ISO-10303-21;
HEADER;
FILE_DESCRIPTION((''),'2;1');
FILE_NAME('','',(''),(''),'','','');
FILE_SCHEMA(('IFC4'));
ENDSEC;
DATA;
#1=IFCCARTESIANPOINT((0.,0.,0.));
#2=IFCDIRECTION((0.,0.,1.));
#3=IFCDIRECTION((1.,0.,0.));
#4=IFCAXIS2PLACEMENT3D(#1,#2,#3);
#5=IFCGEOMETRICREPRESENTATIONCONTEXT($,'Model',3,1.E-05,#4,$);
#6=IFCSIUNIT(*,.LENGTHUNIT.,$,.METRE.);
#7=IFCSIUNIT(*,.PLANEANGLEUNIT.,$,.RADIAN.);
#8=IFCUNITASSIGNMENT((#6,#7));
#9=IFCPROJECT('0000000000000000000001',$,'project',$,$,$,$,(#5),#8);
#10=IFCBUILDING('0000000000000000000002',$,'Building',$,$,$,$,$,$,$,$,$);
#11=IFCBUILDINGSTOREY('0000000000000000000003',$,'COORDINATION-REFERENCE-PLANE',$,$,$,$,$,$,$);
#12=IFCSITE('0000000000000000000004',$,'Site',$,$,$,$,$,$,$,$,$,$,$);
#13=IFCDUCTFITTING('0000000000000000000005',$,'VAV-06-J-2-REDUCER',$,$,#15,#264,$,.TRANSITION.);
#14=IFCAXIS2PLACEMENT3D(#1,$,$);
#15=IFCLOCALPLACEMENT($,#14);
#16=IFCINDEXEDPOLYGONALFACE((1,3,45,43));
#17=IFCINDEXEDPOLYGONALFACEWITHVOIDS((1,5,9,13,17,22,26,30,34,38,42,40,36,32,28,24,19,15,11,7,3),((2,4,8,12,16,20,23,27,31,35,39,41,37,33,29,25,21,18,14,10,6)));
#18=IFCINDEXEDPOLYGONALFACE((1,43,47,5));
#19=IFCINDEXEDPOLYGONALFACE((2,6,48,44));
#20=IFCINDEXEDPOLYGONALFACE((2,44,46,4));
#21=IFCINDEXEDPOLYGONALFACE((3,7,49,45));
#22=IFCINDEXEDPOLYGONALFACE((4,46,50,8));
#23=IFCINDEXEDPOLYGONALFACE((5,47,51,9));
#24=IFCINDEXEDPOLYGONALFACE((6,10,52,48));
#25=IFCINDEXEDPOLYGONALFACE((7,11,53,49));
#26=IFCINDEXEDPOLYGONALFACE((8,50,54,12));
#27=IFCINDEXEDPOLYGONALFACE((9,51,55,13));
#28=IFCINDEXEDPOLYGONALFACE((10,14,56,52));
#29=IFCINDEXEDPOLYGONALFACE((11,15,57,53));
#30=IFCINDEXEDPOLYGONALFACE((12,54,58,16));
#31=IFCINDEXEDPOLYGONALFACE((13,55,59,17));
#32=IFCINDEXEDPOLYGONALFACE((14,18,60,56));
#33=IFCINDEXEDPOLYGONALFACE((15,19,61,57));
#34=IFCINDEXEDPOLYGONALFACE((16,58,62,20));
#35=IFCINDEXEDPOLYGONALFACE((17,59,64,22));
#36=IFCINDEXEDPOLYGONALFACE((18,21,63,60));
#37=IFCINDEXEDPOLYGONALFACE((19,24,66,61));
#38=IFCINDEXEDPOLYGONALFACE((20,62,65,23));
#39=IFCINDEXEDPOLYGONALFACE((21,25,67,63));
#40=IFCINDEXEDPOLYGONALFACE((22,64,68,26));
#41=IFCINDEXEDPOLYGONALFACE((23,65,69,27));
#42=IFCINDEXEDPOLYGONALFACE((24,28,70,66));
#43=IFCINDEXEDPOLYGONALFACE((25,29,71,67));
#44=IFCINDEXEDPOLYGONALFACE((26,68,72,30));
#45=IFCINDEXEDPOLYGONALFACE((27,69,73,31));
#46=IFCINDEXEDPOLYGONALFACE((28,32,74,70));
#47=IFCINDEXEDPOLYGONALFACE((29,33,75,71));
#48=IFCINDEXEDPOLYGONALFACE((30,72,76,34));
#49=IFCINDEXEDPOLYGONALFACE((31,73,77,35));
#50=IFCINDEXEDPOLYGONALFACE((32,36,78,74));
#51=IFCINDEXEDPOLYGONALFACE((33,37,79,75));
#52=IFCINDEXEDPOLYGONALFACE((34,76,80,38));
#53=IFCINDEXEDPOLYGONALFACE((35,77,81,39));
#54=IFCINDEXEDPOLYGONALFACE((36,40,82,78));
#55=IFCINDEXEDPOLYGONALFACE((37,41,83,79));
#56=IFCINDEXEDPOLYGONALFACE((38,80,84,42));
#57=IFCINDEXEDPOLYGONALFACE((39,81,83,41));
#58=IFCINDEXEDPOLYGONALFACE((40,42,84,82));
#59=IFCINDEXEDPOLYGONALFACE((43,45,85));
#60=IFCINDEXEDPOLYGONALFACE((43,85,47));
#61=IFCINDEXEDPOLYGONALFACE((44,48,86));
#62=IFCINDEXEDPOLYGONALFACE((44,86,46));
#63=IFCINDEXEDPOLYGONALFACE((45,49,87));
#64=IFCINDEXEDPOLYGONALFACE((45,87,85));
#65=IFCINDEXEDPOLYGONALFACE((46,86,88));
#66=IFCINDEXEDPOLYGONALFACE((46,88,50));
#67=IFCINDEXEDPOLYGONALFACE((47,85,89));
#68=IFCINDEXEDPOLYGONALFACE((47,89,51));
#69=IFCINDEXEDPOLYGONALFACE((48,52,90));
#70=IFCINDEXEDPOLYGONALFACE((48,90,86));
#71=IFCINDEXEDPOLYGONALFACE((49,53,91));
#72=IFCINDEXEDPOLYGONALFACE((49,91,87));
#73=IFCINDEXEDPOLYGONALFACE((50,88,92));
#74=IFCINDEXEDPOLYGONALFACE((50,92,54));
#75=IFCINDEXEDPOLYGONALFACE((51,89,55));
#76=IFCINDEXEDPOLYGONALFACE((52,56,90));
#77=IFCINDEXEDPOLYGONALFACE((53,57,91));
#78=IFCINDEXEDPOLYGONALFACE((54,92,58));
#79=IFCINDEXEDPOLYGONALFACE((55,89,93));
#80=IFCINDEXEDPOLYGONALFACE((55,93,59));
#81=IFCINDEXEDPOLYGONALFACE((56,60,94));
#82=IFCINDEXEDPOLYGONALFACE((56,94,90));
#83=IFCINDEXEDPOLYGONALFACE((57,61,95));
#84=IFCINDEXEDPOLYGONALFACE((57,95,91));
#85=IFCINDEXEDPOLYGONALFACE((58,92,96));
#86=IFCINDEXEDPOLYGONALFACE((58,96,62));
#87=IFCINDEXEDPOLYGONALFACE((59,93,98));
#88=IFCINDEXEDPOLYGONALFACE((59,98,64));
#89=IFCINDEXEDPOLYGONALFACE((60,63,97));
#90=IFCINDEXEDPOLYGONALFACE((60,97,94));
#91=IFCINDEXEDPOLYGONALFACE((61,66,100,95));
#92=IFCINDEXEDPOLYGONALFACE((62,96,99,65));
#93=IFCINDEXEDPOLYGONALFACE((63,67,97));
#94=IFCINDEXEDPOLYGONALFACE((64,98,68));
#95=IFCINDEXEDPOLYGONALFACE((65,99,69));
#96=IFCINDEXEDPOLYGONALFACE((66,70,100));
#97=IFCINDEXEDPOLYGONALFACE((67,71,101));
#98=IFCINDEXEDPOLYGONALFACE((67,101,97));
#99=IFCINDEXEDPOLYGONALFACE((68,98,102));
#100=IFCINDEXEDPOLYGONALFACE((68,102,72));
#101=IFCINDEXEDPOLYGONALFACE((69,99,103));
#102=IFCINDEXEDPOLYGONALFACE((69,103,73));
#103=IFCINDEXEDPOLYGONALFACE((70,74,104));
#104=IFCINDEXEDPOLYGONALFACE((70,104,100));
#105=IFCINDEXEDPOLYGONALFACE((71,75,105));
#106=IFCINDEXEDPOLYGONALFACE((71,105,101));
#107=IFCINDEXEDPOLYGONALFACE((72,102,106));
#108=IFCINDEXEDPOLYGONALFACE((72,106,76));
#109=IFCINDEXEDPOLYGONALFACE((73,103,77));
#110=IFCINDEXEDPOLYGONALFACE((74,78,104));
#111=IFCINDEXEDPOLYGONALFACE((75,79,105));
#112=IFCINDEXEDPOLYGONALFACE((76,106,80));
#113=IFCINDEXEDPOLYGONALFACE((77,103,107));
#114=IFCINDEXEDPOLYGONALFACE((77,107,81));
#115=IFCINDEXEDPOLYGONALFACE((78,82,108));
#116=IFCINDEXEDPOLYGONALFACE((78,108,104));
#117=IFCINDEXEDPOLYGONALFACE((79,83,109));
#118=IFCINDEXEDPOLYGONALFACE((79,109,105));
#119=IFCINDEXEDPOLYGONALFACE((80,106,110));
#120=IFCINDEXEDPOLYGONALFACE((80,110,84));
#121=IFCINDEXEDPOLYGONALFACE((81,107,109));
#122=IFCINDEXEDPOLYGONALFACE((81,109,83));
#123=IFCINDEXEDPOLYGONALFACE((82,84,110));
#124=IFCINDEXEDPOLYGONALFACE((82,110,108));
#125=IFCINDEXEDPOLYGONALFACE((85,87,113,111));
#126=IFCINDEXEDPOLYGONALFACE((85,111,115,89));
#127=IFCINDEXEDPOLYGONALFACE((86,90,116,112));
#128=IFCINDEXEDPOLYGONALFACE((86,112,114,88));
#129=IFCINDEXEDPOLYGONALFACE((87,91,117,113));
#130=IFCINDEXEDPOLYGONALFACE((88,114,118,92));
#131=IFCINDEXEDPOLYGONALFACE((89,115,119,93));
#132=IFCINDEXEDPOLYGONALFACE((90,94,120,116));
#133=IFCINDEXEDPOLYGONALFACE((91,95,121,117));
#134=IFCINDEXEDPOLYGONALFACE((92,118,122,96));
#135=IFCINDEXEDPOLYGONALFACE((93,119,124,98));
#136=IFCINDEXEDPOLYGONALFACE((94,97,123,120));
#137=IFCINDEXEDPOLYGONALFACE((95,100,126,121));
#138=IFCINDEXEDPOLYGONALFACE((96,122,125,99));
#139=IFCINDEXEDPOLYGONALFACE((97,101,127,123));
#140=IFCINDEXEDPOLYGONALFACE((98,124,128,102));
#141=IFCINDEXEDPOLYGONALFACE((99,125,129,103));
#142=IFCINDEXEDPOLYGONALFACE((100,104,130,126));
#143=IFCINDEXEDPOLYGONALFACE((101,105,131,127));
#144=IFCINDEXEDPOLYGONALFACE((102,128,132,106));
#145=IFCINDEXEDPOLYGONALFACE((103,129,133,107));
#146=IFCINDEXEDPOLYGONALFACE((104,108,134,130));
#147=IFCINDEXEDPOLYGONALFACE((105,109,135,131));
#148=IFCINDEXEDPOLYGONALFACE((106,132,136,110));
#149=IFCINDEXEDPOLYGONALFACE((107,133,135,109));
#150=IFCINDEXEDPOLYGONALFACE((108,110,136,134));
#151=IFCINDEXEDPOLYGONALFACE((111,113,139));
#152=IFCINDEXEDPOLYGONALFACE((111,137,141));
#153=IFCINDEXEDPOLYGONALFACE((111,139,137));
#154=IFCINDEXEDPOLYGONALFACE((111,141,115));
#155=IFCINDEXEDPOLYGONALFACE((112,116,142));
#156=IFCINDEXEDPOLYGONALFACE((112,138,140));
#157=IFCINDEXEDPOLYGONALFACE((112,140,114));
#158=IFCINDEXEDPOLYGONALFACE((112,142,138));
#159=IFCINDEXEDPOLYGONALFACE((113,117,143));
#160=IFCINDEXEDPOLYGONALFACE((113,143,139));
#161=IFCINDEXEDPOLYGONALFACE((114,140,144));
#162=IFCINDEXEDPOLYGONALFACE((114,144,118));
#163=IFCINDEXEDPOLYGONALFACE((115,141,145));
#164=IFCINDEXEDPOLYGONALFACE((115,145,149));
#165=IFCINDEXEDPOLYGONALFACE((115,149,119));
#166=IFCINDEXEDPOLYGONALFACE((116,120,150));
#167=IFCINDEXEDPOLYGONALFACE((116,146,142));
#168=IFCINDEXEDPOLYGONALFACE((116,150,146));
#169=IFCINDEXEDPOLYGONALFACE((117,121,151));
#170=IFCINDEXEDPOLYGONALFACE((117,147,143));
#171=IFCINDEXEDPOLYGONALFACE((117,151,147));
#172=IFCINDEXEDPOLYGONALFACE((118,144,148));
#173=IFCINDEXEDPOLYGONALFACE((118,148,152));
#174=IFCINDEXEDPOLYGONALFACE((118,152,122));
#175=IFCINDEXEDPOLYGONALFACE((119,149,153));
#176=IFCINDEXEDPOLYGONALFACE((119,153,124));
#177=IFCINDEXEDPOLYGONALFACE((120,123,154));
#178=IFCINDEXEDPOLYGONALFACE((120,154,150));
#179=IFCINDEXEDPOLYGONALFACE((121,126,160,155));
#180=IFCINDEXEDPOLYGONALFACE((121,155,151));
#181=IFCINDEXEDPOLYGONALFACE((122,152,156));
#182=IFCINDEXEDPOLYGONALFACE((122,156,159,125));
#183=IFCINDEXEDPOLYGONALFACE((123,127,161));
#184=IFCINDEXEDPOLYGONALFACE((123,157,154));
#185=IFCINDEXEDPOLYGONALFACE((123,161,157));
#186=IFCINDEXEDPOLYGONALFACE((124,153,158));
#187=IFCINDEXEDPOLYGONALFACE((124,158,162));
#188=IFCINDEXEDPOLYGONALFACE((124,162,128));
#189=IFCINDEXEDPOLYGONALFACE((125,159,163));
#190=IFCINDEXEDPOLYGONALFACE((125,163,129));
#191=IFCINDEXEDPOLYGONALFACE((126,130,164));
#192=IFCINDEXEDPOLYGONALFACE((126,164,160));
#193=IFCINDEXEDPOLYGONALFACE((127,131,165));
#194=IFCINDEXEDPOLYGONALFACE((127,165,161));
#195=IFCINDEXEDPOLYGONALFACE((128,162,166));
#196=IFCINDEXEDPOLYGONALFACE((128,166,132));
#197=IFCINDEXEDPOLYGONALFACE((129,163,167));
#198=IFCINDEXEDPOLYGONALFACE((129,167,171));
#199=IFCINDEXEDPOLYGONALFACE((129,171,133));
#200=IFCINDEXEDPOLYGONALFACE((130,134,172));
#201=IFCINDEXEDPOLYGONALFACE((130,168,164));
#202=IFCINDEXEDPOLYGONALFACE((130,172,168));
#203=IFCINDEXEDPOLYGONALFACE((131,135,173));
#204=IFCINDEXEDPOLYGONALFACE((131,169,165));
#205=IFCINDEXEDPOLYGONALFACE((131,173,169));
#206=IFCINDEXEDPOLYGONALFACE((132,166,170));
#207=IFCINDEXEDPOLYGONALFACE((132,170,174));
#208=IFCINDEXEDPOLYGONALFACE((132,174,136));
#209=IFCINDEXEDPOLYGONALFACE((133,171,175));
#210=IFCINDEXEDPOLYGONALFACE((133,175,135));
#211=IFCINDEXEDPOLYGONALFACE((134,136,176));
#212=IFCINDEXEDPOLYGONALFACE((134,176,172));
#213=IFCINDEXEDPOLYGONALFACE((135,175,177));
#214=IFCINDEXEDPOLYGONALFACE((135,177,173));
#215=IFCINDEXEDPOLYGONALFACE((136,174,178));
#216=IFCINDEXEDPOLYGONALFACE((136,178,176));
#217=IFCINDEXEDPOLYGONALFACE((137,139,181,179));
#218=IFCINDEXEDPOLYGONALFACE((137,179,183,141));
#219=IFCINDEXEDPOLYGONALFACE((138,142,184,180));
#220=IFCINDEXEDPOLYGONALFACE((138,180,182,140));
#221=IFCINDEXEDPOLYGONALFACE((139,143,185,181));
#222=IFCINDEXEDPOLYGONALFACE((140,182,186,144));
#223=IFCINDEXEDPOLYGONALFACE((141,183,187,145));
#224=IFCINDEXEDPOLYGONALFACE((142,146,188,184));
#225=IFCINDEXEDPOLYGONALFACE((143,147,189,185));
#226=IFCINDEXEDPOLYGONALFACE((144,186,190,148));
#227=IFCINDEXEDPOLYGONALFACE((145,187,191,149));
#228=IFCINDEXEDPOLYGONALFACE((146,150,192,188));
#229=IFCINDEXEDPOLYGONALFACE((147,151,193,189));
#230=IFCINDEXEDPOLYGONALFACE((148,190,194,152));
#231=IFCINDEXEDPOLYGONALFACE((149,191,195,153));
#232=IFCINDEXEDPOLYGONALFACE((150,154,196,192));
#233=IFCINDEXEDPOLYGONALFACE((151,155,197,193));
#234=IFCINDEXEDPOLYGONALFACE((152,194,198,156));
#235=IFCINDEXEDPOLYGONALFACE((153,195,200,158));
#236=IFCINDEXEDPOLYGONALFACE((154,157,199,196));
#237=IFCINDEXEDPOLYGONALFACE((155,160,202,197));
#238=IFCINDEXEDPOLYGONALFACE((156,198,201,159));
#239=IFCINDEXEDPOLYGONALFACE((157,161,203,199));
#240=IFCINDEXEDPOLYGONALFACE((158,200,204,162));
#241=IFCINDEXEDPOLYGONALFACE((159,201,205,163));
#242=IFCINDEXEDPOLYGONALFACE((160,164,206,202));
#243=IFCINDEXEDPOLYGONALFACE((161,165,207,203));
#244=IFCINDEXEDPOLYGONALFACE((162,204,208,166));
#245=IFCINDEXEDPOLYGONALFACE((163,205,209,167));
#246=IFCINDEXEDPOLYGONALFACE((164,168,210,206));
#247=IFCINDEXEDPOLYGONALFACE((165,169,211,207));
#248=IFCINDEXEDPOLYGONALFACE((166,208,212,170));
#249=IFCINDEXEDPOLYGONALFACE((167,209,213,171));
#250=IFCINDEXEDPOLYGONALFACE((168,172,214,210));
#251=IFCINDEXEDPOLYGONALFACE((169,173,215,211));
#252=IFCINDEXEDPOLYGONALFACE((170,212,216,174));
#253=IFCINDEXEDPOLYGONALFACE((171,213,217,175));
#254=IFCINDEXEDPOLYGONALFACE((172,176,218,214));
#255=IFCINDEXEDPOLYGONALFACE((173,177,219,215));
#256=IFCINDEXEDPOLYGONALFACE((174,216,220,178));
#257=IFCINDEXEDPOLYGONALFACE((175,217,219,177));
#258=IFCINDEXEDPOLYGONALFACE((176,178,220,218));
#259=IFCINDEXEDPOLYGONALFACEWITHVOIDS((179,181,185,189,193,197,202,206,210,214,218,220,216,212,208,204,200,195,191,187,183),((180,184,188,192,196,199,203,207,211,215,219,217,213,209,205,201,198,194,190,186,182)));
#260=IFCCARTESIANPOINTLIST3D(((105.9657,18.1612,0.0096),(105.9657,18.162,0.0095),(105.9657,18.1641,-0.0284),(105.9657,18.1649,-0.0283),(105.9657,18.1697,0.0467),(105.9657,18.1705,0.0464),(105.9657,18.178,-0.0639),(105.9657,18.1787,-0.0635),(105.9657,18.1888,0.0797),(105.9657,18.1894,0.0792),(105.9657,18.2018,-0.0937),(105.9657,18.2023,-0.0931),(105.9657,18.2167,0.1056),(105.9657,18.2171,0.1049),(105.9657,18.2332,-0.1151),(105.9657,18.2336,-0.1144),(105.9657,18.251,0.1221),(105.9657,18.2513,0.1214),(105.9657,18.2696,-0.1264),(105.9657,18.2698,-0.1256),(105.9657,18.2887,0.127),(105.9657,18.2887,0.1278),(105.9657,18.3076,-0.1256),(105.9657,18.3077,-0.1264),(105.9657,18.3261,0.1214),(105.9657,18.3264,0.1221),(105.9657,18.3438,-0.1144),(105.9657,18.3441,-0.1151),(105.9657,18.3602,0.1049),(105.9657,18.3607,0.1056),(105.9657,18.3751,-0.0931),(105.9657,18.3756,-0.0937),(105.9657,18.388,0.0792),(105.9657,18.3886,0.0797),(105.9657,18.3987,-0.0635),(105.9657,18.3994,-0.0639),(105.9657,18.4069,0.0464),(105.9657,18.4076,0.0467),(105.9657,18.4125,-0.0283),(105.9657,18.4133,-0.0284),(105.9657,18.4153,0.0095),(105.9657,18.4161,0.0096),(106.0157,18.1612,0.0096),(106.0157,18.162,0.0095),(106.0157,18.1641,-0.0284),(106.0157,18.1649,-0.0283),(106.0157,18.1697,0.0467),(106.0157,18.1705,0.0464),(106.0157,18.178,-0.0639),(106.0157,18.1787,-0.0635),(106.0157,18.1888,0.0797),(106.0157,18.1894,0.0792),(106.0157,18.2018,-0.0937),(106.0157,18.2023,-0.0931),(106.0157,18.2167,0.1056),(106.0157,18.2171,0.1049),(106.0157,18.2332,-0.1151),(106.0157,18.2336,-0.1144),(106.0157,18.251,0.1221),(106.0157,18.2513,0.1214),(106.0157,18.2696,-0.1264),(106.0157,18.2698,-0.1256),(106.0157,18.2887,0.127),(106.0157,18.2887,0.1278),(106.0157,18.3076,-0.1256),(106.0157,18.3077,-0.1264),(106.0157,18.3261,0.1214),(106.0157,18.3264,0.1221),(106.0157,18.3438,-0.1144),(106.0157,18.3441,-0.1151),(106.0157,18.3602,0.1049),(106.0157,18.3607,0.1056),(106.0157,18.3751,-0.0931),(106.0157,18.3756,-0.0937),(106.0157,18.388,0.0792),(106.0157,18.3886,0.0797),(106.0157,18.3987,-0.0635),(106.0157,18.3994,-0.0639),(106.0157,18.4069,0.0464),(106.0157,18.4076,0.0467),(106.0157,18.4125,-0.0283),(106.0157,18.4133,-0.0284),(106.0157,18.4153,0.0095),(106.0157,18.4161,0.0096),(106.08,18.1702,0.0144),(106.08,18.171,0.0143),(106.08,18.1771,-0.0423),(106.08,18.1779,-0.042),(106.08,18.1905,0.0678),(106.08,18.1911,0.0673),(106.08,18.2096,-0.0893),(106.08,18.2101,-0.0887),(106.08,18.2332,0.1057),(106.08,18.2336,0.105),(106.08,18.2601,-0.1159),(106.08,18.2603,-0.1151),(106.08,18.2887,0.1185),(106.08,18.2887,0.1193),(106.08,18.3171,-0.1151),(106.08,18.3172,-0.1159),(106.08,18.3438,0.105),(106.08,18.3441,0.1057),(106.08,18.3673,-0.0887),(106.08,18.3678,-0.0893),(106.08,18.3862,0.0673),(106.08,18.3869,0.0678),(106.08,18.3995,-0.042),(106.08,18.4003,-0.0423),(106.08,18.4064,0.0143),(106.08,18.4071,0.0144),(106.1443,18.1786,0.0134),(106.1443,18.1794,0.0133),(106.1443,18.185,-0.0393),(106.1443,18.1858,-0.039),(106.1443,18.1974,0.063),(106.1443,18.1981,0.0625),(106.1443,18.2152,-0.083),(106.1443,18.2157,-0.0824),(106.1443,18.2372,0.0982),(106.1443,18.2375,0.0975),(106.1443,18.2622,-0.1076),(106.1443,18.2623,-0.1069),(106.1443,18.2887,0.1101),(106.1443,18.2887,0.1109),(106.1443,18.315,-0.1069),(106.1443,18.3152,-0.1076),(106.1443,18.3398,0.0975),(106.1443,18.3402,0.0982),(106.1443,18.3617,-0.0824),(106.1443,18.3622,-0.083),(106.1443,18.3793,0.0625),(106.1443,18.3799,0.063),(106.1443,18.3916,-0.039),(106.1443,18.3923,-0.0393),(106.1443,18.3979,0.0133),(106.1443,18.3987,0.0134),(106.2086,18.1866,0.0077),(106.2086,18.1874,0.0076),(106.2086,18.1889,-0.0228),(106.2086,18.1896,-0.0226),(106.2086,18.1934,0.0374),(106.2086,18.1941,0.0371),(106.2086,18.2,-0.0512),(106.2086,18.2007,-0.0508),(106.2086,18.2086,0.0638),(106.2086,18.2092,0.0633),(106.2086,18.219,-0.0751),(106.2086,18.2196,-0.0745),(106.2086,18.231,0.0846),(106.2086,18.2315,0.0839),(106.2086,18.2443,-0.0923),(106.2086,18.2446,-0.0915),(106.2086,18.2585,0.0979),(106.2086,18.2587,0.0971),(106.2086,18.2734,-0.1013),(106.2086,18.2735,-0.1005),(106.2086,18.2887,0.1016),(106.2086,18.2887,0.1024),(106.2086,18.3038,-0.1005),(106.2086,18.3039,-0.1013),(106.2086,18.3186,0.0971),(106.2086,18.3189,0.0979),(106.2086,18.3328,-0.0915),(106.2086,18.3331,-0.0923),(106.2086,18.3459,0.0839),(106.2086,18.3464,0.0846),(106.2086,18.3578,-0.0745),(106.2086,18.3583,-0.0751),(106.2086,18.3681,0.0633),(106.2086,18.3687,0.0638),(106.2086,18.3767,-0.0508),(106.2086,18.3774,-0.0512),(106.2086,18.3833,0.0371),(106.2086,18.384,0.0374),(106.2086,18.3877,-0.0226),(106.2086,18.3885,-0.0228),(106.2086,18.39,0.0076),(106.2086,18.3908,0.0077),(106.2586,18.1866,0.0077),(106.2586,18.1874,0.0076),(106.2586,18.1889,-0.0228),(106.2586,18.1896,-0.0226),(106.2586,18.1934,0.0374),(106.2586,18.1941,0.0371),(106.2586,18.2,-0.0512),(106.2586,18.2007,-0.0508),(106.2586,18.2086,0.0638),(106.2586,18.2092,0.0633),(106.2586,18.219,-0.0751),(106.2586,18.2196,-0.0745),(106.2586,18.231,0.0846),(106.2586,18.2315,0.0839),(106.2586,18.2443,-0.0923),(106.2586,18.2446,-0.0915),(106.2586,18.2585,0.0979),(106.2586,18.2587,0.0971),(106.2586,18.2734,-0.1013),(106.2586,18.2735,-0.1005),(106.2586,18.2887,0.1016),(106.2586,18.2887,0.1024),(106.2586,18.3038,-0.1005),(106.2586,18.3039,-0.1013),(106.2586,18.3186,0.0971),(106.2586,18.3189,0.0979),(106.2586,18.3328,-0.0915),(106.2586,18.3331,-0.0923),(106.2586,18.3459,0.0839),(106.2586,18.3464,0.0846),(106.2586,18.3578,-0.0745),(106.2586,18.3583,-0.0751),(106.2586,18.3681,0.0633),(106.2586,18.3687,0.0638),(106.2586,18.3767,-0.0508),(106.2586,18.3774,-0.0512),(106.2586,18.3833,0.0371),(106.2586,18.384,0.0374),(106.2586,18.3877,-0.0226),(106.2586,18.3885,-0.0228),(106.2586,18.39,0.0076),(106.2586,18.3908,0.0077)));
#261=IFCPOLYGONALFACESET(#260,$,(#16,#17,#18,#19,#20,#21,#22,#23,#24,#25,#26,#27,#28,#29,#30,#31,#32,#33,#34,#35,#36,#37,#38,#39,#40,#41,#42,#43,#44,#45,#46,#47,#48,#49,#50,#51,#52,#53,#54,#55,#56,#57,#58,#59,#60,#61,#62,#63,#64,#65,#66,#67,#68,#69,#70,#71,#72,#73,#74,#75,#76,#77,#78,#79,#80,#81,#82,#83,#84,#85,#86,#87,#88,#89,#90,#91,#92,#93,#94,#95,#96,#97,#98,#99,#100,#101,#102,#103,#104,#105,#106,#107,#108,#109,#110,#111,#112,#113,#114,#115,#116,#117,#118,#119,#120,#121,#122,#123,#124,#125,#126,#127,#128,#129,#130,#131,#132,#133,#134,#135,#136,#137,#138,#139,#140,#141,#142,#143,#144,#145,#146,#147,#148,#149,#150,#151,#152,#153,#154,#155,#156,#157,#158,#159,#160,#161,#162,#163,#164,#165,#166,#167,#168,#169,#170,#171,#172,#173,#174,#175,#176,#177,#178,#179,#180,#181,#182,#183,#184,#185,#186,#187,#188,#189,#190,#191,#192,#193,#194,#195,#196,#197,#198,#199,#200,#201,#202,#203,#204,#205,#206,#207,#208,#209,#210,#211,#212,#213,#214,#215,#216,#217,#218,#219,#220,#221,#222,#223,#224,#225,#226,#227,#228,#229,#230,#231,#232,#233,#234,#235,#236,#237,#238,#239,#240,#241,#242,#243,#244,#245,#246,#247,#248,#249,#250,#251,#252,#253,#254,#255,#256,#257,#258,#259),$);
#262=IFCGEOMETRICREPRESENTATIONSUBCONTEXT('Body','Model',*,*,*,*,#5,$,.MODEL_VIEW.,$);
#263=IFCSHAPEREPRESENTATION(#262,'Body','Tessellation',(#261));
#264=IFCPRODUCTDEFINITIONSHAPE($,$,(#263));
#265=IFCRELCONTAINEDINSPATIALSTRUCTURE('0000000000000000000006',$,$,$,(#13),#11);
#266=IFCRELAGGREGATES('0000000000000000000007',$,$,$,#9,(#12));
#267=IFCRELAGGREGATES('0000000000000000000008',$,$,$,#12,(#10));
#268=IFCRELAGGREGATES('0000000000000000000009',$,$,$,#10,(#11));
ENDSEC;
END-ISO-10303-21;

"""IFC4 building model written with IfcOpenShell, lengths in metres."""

from ifc_helpers import new_model, entity, si_unit, frame, origin_with_axes, place, context, subcontext, project, spatial, element, save


model = new_model("IFC4")

# Units and contexts
model_context = context("Model", 3, precision=1e-05, world=origin_with_axes())
body_context_1 = subcontext(model_context, "Body", "Model", "MODEL_VIEW")
ifc_project = project(units=[si_unit("LENGTHUNIT", "METRE"), si_unit("PLANEANGLEUNIT", "RADIAN")], contexts=[model_context])

# Site, building, storey
site = spatial("IfcSite", under=ifc_project, Name="Site")
building = spatial("IfcBuilding", under=site, Name="Building")
storey = spatial("IfcBuildingStorey", under=building, Name="COORDINATION-REFERENCE-PLANE")

# Duct fitting
for number, where, z_axis, x_axis, name in (
    (1, (105.9657, 18.2887, 0.0), (0.0, 1.0, 0.0), (0.0, 0.0, 1.0), "VAV-06-J-2-REDUCER"),
):
    element("IfcDuctFitting", number, at=place(None, frame(where, z_axis=z_axis, x_axis=x_axis)), inside=storey, Name=name, PredefinedType="TRANSITION", context=body_context_1, shape_type="SweptSolid", body=[
        entity("IfcRevolvedAreaSolid", entity("IfcArbitraryClosedProfileDef", "AREA", None, entity("IfcPolyline", [entity("IfcCartesianPoint", [0.1278, 0.0]), entity("IfcCartesianPoint", [0.1278, 0.05]), entity("IfcCartesianPoint", [0.1024, 0.2429]), entity("IfcCartesianPoint", [0.1024, 0.2929]), entity("IfcCartesianPoint", [0.1016, 0.2929]), entity("IfcCartesianPoint", [0.1016, 0.2429]), entity("IfcCartesianPoint", [0.127, 0.05]), entity("IfcCartesianPoint", [0.127, 0.0]), entity("IfcCartesianPoint", [0.1278, 0.0])])), entity("IfcAxis2Placement3D", entity("IfcCartesianPoint", [0.0, 0.0, 0.0])), entity("IfcAxis1Placement", entity("IfcCartesianPoint", [0.0, 0.0, 0.0]), entity("IfcDirection", [0.0, 1.0, 0.0])), 6.283185),
    ])

save(model, "model.ifc")
